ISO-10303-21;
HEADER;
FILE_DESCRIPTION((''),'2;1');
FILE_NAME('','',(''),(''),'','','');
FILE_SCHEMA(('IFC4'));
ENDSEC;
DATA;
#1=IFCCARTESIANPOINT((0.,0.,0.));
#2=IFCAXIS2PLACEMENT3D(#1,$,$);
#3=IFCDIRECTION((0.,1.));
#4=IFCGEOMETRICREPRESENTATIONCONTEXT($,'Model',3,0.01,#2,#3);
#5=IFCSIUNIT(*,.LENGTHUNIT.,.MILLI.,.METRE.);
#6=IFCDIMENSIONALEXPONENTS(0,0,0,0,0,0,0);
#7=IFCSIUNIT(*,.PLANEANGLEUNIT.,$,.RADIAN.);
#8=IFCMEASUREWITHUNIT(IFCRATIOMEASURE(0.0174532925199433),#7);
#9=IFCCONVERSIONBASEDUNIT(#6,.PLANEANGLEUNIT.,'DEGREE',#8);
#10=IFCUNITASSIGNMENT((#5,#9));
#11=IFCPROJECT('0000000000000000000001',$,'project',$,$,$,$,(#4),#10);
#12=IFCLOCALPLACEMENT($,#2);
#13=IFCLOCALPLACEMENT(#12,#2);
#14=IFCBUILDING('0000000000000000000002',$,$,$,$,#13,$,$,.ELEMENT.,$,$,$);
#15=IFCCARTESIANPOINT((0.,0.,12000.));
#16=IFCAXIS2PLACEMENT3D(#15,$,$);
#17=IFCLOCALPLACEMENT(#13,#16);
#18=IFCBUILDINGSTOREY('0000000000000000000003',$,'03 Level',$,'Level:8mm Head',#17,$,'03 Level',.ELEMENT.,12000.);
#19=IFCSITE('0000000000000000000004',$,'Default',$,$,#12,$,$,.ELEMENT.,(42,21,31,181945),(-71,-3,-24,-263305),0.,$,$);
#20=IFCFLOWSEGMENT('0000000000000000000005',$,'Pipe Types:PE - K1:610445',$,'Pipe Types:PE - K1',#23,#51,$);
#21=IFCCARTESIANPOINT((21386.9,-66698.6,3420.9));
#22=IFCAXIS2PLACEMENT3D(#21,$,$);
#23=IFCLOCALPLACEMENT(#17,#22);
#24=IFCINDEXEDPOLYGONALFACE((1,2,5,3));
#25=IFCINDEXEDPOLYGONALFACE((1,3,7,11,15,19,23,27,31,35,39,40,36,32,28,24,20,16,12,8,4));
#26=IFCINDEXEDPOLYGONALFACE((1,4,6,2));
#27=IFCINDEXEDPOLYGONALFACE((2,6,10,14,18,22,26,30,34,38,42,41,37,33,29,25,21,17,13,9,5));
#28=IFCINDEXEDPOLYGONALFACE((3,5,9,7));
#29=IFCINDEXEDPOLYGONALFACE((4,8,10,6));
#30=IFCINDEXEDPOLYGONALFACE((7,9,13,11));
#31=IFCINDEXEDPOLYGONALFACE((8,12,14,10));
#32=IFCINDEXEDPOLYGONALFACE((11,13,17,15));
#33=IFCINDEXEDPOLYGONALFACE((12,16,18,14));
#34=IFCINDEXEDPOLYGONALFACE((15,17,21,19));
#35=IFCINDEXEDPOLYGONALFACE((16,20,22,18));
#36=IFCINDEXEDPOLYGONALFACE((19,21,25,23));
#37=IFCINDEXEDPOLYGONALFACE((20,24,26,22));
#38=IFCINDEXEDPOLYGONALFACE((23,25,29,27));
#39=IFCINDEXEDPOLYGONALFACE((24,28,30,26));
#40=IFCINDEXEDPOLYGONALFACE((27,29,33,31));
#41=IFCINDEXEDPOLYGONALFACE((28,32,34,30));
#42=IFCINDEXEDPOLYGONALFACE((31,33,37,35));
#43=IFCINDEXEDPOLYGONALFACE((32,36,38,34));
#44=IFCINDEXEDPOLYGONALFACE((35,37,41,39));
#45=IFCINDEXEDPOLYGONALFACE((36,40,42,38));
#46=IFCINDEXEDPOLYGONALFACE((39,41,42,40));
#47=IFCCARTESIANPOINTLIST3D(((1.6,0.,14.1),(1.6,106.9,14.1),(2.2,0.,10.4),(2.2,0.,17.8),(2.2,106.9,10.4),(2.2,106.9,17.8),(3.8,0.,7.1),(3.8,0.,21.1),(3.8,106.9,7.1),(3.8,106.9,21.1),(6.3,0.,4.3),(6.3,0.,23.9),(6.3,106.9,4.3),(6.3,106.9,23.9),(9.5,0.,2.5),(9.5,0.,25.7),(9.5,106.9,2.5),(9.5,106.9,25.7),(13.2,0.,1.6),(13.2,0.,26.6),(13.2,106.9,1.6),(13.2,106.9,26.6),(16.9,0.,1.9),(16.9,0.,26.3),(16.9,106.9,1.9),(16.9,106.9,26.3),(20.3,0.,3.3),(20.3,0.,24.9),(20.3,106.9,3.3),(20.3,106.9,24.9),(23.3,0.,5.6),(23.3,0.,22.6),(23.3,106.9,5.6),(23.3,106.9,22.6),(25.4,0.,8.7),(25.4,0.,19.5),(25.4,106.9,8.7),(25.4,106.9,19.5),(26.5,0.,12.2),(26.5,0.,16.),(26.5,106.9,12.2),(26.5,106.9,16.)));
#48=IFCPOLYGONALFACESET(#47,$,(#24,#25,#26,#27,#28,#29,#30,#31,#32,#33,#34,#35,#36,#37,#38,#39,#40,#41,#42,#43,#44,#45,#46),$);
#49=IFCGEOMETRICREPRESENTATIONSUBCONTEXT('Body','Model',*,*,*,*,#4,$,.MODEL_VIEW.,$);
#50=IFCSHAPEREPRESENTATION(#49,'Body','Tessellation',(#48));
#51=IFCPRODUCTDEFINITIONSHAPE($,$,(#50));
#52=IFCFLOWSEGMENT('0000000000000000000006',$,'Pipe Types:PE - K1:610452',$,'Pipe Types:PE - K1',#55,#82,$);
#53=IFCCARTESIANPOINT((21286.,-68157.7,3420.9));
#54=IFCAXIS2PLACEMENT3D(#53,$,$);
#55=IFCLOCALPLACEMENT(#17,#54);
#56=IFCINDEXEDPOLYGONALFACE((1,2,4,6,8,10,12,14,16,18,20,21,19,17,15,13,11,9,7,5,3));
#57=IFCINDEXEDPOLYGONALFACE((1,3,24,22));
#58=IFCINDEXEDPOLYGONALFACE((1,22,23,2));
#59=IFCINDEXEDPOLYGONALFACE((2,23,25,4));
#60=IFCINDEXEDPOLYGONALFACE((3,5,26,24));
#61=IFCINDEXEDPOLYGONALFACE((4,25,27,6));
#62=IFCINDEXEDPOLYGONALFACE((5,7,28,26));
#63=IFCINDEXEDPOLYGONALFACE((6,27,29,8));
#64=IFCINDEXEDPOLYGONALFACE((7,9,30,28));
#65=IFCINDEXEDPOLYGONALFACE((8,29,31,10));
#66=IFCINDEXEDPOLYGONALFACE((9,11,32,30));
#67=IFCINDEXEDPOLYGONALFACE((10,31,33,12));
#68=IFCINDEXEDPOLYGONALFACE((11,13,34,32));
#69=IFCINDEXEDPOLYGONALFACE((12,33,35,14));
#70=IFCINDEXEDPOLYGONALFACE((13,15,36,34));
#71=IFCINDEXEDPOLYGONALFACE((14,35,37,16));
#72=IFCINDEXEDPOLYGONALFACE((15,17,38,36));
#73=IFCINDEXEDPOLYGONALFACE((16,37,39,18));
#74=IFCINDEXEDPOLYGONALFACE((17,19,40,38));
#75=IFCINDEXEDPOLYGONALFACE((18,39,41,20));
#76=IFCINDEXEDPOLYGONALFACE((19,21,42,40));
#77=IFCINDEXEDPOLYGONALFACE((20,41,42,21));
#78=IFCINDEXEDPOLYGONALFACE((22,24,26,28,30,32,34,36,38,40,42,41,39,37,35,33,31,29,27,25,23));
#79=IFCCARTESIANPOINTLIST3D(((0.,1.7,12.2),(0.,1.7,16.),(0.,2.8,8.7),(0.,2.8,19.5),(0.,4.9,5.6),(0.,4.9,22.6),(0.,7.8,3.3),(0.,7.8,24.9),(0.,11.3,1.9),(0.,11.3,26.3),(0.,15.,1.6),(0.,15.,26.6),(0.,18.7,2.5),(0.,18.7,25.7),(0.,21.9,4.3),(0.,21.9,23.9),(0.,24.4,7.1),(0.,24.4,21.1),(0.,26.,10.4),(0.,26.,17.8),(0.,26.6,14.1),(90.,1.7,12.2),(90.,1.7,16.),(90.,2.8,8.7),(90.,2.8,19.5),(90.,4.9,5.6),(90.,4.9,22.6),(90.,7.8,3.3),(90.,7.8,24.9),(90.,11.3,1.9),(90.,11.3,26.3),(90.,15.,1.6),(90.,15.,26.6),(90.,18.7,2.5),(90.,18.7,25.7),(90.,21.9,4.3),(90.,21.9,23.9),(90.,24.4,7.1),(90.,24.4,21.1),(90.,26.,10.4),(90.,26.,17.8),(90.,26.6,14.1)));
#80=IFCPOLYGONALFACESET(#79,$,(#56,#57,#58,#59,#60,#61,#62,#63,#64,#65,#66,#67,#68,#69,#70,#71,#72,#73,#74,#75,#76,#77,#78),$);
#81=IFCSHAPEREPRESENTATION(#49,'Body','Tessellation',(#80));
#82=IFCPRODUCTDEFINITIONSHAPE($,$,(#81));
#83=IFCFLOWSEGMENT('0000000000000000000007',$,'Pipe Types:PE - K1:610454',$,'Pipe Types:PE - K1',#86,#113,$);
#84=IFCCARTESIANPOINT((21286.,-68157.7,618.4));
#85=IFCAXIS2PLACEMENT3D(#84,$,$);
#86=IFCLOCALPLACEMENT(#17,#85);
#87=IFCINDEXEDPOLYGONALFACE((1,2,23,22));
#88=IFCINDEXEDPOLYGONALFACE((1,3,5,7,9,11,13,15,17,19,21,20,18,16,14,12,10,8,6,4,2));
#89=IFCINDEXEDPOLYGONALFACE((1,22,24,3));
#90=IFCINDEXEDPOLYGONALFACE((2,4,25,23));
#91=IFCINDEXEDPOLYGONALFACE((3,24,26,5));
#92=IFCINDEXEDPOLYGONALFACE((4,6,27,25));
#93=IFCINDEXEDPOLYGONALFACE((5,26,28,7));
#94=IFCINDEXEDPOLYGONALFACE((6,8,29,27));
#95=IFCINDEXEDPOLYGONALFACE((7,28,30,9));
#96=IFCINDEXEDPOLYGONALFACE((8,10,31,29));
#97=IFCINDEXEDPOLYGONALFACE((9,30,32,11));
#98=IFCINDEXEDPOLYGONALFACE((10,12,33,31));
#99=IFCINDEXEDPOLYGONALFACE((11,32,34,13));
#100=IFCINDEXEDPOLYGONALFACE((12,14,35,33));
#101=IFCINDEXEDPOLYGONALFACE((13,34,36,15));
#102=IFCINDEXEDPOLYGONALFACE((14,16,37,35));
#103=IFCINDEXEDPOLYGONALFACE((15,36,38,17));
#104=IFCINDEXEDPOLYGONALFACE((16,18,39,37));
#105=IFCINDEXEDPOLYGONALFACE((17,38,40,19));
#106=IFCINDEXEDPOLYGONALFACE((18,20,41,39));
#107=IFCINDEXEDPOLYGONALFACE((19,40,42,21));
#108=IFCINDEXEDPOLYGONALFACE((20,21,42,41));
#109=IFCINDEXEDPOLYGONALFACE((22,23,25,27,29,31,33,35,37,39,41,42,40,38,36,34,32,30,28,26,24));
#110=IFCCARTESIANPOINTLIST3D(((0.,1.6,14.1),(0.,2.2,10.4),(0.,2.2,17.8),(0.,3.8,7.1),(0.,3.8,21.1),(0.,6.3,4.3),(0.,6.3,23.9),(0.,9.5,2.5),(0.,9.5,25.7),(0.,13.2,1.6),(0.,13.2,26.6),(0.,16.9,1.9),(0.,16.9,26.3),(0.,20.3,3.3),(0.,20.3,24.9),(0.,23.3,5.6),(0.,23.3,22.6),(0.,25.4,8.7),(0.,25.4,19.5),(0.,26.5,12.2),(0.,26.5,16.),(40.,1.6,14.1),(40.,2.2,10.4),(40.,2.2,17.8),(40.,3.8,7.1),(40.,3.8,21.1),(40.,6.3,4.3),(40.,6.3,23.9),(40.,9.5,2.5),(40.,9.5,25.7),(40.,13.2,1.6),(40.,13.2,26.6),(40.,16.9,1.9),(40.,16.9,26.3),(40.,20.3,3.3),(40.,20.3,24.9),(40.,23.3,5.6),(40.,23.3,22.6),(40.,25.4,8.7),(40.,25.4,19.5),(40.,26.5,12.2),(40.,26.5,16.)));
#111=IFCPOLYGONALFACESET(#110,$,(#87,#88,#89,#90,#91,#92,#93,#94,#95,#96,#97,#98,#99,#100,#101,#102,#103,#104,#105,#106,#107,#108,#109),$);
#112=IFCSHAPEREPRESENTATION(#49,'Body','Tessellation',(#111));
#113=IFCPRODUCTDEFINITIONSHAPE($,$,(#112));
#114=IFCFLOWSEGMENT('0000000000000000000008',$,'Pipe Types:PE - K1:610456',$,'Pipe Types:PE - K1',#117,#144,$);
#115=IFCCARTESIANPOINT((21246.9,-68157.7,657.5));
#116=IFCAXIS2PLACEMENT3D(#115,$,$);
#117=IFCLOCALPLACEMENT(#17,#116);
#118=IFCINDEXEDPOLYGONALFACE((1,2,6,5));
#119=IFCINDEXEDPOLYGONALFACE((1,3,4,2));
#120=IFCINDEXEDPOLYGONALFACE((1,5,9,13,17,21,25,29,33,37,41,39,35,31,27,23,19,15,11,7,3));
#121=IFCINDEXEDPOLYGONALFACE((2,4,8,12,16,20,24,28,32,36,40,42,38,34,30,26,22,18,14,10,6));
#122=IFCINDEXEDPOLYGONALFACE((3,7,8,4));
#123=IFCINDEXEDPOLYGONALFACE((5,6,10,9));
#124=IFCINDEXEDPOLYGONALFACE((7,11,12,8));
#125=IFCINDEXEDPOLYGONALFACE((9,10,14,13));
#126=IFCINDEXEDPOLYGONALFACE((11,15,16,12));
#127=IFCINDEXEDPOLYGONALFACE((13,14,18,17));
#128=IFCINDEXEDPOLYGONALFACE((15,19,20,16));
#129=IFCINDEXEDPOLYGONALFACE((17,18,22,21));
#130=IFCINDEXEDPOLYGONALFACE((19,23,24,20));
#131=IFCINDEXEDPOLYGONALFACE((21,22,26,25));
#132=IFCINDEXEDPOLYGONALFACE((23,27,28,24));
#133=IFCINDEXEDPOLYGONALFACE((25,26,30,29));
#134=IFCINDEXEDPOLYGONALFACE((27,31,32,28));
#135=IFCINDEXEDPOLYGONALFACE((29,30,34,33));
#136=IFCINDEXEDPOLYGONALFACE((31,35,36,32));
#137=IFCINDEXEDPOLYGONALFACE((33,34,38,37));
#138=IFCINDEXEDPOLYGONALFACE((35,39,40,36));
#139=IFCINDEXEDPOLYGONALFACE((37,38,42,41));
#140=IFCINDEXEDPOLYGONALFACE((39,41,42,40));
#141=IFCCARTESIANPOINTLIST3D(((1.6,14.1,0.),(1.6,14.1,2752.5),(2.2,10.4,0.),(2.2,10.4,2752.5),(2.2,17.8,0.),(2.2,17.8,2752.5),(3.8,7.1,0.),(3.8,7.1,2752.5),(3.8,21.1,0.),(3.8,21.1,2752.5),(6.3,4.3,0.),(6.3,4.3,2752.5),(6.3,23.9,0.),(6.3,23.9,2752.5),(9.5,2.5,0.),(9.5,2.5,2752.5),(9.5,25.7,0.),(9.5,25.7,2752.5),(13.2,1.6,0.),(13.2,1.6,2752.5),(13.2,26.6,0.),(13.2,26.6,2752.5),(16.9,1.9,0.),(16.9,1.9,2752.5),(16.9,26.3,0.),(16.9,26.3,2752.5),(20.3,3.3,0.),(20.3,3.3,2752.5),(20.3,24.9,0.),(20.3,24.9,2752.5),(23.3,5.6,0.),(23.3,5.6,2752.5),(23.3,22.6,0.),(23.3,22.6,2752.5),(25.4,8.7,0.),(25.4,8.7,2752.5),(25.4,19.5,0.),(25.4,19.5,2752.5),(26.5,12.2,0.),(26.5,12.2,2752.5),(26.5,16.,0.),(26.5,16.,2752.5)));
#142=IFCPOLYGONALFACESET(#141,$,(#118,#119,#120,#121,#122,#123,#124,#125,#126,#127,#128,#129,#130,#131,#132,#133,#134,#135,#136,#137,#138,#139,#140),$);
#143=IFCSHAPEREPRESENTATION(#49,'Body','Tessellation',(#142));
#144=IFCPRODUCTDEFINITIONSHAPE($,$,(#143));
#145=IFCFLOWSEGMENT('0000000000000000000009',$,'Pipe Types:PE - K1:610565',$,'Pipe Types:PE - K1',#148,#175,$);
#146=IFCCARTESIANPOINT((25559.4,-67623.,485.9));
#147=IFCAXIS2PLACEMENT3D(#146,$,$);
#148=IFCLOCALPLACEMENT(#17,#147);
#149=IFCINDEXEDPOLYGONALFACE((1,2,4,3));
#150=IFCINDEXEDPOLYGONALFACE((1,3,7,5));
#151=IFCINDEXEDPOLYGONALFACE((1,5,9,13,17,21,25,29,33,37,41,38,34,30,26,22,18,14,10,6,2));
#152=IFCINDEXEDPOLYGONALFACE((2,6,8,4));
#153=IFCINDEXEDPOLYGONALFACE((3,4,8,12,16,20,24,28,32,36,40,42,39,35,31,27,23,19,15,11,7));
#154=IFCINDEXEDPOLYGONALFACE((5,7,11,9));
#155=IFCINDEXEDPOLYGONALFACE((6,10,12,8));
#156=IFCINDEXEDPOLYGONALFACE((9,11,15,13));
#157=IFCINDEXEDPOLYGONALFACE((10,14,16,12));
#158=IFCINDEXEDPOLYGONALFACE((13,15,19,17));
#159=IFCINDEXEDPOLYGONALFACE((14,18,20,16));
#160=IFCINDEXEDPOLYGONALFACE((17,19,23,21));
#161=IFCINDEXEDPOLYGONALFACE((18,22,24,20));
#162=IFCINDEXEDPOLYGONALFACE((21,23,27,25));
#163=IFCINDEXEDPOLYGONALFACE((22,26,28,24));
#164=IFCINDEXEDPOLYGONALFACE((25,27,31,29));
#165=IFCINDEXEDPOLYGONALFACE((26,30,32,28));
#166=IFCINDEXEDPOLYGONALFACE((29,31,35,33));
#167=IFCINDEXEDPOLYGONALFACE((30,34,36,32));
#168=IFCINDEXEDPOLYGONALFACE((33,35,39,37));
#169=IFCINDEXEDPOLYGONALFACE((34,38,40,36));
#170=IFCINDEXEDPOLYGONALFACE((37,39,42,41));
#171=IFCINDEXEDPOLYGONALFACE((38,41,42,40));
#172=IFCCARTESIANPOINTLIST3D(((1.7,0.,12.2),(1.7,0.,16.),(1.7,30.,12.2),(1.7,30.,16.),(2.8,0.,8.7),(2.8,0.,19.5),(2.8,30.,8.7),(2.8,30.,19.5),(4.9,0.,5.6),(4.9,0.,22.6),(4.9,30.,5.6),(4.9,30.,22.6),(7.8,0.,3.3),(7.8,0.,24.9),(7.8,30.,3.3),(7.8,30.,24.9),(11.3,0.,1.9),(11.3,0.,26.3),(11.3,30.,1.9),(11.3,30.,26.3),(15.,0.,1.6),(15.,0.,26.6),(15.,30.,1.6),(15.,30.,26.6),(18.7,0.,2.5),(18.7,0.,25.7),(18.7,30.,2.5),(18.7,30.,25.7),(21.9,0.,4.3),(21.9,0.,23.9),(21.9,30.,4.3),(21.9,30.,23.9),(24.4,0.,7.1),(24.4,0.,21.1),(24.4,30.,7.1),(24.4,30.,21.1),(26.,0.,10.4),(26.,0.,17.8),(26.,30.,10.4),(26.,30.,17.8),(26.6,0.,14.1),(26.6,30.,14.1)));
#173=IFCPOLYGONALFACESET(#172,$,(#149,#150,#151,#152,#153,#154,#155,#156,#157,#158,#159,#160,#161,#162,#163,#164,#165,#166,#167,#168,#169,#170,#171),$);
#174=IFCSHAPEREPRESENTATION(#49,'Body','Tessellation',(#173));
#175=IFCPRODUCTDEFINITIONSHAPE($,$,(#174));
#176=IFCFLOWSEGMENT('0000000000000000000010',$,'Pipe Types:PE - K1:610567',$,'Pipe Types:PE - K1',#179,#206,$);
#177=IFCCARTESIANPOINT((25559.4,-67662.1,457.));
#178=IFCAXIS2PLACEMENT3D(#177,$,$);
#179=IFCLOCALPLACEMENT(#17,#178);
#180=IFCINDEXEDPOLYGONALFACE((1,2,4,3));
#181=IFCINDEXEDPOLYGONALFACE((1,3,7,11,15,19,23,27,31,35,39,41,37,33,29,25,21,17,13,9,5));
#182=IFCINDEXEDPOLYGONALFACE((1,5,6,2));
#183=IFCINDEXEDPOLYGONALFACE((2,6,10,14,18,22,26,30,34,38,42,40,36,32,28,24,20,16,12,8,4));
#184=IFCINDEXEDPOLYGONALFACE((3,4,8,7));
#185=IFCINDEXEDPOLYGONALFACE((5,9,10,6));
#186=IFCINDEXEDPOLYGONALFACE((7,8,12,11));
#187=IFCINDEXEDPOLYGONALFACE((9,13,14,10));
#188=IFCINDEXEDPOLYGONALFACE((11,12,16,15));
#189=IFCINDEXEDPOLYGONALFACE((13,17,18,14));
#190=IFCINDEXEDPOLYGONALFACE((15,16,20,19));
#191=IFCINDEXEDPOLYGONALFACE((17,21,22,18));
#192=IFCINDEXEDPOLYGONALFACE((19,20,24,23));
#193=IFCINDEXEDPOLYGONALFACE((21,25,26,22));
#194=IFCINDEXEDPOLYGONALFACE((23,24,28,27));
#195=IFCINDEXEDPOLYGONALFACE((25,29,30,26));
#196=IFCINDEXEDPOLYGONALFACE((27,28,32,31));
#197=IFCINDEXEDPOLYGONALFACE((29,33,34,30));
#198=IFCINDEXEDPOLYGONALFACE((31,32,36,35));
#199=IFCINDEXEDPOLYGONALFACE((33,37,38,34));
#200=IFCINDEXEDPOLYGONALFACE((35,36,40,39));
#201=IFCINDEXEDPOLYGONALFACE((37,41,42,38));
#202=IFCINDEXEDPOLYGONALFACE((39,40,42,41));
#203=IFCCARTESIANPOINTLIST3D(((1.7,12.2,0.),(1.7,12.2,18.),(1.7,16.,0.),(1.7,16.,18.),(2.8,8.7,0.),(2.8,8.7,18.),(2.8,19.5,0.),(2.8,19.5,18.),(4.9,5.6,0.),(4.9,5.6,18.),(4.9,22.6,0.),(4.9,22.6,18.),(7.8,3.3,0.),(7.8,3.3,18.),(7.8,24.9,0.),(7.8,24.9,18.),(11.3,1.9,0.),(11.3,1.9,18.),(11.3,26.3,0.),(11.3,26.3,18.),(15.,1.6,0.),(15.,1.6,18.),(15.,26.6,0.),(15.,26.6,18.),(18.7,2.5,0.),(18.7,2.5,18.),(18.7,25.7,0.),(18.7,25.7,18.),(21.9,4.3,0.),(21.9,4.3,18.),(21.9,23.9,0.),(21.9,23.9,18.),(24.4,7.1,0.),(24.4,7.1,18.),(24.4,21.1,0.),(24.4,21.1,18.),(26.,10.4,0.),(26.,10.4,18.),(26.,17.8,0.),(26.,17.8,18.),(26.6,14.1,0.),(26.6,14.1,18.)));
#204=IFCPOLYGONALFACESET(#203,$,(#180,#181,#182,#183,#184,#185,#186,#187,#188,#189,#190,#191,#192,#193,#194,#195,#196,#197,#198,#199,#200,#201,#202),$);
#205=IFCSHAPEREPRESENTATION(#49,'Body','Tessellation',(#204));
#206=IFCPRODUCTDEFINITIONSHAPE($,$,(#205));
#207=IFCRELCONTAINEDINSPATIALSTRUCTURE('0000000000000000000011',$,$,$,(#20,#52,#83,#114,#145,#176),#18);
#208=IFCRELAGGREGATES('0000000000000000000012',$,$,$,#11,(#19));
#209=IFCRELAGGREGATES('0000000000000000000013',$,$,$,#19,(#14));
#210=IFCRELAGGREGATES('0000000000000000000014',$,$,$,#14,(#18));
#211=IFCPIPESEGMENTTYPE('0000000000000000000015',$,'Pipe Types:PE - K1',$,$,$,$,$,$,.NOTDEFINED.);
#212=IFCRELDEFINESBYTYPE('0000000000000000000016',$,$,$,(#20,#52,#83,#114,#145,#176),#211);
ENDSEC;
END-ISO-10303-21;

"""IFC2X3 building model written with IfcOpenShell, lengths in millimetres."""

from ifc_helpers import new_model, entity, si_unit, converted_unit, direction, frame, frame_2d, origin, origin_2d_with_axis, place, context, subcontext, project, spatial, circle, extrude, type_object, element, save


model = new_model("IFC2X3")

# Units and contexts
model_context = context("Model", 3, precision=0.01, world=origin(), true_north=direction((0.0, 1.0)))
body_context = subcontext(model_context, "Body", "Model", "MODEL_VIEW")
ifc_project = project(units=[si_unit("LENGTHUNIT", "METRE", prefix="MILLI"), converted_unit("PLANEANGLEUNIT", "DEGREE", entity("IfcRatioMeasure", 0.0174532925199433), si_unit("PLANEANGLEUNIT", "RADIAN"), dimensions=[0, 0, 0, 0, 0, 0, 0])], contexts=[model_context])

# Site, building, storey
site_placement = place(None, origin())
site = spatial("IfcSite", under=ifc_project, at=site_placement, Name="Default", CompositionType="ELEMENT", RefLatitude=(42, 21, 31, 181945), RefLongitude=(-71, -3, -24, -263305), RefElevation=0.0)
building_placement = place(site_placement, origin())
building = spatial("IfcBuilding", under=site, at=building_placement, CompositionType="ELEMENT")
storey_placement = place(building_placement, frame((0.0, 0.0, 12000.0)))
storey = spatial("IfcBuildingStorey", under=building, at=storey_placement, Name="03 Level", ObjectType="Level:8mm Head", LongName="03 Level", CompositionType="ELEMENT", Elevation=12000.0)

# Flow segments
pipe_segment_type = type_object("IfcPipeSegmentType", Name="Pipe Types:PE - K1", PredefinedType="NOTDEFINED")
flow_segment_1_placement = place(storey_placement, frame((21386.9, -66698.6, 3420.9)))
element("IfcFlowSegment", 1, at=flow_segment_1_placement, inside=storey, type_object=pipe_segment_type, Name="Pipe Types:PE - K1:610445", ObjectType="Pipe Types:PE - K1", context=body_context, shape_type="SweptSolid", body=[
    extrude(circle(Radius=12.5, at=frame_2d((0.0, 0.0), x_axis=(1.0, 0.0))), frame((14.1, 0.0, 14.1), z_axis=(0.0, 1.0, 0.0), x_axis=(-1.0, 0.0, 0.0)), (0.0, 0.0, 1.0), 106.9),
])
flow_segment_2_placement = place(storey_placement, frame((21286.0, -68157.7, 3420.9)))
element("IfcFlowSegment", 2, at=flow_segment_2_placement, inside=storey, type_object=pipe_segment_type, Name="Pipe Types:PE - K1:610452", ObjectType="Pipe Types:PE - K1", context=body_context, shape_type="SweptSolid", body=[
    extrude(circle(Radius=12.5, at=frame_2d((0.0, 0.0), x_axis=(1.0, 0.0))), frame((0.0, 14.1, 14.1), z_axis=(1.0, 0.0, 0.0), x_axis=(0.0, 1.0, 0.0)), (0.0, 0.0, 1.0), 90.0),
])
flow_segment_3_placement = place(storey_placement, frame((21286.0, -68157.7, 618.4)))
element("IfcFlowSegment", 3, at=flow_segment_3_placement, inside=storey, type_object=pipe_segment_type, Name="Pipe Types:PE - K1:610454", ObjectType="Pipe Types:PE - K1", context=body_context, shape_type="SweptSolid", body=[
    extrude(circle(Radius=12.5, at=origin_2d_with_axis()), frame((0.0, 14.1, 14.1), z_axis=(1.0, 0.0, 0.0), x_axis=(0.0, -1.0, 0.0)), (0.0, 0.0, 1.0), 40.0),
])
flow_segment_4_placement = place(storey_placement, frame((21246.9, -68157.7, 657.5)))
element("IfcFlowSegment", 4, at=flow_segment_4_placement, inside=storey, type_object=pipe_segment_type, Name="Pipe Types:PE - K1:610456", ObjectType="Pipe Types:PE - K1", context=body_context, shape_type="SweptSolid", body=[
    extrude(circle(Radius=12.5, at=origin_2d_with_axis()), frame((14.1, 14.1, 0.0), z_axis=(0.0, 0.0, 1.0), x_axis=(-1.0, 0.0, 0.0)), (0.0, 0.0, 1.0), 2752.5),
])
flow_segment_5_placement = place(storey_placement, frame((25559.4, -67623.0, 485.9)))
element("IfcFlowSegment", 5, at=flow_segment_5_placement, inside=storey, type_object=pipe_segment_type, Name="Pipe Types:PE - K1:610565", ObjectType="Pipe Types:PE - K1", context=body_context, shape_type="SweptSolid", body=[
    extrude(circle(Radius=12.5, at=origin_2d_with_axis()), frame((14.1, 0.0, 14.1), z_axis=(0.0, 1.0, 0.0), x_axis=(1.0, 0.0, 0.0)), (0.0, 0.0, 1.0), 30.0),
])
flow_segment_6_placement = place(storey_placement, frame((25559.4, -67662.1, 457.0)))
element("IfcFlowSegment", 6, at=flow_segment_6_placement, inside=storey, type_object=pipe_segment_type, Name="Pipe Types:PE - K1:610567", ObjectType="Pipe Types:PE - K1", context=body_context, shape_type="SweptSolid", body=[
    extrude(circle(Radius=12.5, at=frame_2d((0.0, 0.0), x_axis=(1.0, 0.0))), frame((14.1, 14.1, 0.0)), (0.0, 0.0, 1.0), 18.0),
])

save(model, "model.ifc")
